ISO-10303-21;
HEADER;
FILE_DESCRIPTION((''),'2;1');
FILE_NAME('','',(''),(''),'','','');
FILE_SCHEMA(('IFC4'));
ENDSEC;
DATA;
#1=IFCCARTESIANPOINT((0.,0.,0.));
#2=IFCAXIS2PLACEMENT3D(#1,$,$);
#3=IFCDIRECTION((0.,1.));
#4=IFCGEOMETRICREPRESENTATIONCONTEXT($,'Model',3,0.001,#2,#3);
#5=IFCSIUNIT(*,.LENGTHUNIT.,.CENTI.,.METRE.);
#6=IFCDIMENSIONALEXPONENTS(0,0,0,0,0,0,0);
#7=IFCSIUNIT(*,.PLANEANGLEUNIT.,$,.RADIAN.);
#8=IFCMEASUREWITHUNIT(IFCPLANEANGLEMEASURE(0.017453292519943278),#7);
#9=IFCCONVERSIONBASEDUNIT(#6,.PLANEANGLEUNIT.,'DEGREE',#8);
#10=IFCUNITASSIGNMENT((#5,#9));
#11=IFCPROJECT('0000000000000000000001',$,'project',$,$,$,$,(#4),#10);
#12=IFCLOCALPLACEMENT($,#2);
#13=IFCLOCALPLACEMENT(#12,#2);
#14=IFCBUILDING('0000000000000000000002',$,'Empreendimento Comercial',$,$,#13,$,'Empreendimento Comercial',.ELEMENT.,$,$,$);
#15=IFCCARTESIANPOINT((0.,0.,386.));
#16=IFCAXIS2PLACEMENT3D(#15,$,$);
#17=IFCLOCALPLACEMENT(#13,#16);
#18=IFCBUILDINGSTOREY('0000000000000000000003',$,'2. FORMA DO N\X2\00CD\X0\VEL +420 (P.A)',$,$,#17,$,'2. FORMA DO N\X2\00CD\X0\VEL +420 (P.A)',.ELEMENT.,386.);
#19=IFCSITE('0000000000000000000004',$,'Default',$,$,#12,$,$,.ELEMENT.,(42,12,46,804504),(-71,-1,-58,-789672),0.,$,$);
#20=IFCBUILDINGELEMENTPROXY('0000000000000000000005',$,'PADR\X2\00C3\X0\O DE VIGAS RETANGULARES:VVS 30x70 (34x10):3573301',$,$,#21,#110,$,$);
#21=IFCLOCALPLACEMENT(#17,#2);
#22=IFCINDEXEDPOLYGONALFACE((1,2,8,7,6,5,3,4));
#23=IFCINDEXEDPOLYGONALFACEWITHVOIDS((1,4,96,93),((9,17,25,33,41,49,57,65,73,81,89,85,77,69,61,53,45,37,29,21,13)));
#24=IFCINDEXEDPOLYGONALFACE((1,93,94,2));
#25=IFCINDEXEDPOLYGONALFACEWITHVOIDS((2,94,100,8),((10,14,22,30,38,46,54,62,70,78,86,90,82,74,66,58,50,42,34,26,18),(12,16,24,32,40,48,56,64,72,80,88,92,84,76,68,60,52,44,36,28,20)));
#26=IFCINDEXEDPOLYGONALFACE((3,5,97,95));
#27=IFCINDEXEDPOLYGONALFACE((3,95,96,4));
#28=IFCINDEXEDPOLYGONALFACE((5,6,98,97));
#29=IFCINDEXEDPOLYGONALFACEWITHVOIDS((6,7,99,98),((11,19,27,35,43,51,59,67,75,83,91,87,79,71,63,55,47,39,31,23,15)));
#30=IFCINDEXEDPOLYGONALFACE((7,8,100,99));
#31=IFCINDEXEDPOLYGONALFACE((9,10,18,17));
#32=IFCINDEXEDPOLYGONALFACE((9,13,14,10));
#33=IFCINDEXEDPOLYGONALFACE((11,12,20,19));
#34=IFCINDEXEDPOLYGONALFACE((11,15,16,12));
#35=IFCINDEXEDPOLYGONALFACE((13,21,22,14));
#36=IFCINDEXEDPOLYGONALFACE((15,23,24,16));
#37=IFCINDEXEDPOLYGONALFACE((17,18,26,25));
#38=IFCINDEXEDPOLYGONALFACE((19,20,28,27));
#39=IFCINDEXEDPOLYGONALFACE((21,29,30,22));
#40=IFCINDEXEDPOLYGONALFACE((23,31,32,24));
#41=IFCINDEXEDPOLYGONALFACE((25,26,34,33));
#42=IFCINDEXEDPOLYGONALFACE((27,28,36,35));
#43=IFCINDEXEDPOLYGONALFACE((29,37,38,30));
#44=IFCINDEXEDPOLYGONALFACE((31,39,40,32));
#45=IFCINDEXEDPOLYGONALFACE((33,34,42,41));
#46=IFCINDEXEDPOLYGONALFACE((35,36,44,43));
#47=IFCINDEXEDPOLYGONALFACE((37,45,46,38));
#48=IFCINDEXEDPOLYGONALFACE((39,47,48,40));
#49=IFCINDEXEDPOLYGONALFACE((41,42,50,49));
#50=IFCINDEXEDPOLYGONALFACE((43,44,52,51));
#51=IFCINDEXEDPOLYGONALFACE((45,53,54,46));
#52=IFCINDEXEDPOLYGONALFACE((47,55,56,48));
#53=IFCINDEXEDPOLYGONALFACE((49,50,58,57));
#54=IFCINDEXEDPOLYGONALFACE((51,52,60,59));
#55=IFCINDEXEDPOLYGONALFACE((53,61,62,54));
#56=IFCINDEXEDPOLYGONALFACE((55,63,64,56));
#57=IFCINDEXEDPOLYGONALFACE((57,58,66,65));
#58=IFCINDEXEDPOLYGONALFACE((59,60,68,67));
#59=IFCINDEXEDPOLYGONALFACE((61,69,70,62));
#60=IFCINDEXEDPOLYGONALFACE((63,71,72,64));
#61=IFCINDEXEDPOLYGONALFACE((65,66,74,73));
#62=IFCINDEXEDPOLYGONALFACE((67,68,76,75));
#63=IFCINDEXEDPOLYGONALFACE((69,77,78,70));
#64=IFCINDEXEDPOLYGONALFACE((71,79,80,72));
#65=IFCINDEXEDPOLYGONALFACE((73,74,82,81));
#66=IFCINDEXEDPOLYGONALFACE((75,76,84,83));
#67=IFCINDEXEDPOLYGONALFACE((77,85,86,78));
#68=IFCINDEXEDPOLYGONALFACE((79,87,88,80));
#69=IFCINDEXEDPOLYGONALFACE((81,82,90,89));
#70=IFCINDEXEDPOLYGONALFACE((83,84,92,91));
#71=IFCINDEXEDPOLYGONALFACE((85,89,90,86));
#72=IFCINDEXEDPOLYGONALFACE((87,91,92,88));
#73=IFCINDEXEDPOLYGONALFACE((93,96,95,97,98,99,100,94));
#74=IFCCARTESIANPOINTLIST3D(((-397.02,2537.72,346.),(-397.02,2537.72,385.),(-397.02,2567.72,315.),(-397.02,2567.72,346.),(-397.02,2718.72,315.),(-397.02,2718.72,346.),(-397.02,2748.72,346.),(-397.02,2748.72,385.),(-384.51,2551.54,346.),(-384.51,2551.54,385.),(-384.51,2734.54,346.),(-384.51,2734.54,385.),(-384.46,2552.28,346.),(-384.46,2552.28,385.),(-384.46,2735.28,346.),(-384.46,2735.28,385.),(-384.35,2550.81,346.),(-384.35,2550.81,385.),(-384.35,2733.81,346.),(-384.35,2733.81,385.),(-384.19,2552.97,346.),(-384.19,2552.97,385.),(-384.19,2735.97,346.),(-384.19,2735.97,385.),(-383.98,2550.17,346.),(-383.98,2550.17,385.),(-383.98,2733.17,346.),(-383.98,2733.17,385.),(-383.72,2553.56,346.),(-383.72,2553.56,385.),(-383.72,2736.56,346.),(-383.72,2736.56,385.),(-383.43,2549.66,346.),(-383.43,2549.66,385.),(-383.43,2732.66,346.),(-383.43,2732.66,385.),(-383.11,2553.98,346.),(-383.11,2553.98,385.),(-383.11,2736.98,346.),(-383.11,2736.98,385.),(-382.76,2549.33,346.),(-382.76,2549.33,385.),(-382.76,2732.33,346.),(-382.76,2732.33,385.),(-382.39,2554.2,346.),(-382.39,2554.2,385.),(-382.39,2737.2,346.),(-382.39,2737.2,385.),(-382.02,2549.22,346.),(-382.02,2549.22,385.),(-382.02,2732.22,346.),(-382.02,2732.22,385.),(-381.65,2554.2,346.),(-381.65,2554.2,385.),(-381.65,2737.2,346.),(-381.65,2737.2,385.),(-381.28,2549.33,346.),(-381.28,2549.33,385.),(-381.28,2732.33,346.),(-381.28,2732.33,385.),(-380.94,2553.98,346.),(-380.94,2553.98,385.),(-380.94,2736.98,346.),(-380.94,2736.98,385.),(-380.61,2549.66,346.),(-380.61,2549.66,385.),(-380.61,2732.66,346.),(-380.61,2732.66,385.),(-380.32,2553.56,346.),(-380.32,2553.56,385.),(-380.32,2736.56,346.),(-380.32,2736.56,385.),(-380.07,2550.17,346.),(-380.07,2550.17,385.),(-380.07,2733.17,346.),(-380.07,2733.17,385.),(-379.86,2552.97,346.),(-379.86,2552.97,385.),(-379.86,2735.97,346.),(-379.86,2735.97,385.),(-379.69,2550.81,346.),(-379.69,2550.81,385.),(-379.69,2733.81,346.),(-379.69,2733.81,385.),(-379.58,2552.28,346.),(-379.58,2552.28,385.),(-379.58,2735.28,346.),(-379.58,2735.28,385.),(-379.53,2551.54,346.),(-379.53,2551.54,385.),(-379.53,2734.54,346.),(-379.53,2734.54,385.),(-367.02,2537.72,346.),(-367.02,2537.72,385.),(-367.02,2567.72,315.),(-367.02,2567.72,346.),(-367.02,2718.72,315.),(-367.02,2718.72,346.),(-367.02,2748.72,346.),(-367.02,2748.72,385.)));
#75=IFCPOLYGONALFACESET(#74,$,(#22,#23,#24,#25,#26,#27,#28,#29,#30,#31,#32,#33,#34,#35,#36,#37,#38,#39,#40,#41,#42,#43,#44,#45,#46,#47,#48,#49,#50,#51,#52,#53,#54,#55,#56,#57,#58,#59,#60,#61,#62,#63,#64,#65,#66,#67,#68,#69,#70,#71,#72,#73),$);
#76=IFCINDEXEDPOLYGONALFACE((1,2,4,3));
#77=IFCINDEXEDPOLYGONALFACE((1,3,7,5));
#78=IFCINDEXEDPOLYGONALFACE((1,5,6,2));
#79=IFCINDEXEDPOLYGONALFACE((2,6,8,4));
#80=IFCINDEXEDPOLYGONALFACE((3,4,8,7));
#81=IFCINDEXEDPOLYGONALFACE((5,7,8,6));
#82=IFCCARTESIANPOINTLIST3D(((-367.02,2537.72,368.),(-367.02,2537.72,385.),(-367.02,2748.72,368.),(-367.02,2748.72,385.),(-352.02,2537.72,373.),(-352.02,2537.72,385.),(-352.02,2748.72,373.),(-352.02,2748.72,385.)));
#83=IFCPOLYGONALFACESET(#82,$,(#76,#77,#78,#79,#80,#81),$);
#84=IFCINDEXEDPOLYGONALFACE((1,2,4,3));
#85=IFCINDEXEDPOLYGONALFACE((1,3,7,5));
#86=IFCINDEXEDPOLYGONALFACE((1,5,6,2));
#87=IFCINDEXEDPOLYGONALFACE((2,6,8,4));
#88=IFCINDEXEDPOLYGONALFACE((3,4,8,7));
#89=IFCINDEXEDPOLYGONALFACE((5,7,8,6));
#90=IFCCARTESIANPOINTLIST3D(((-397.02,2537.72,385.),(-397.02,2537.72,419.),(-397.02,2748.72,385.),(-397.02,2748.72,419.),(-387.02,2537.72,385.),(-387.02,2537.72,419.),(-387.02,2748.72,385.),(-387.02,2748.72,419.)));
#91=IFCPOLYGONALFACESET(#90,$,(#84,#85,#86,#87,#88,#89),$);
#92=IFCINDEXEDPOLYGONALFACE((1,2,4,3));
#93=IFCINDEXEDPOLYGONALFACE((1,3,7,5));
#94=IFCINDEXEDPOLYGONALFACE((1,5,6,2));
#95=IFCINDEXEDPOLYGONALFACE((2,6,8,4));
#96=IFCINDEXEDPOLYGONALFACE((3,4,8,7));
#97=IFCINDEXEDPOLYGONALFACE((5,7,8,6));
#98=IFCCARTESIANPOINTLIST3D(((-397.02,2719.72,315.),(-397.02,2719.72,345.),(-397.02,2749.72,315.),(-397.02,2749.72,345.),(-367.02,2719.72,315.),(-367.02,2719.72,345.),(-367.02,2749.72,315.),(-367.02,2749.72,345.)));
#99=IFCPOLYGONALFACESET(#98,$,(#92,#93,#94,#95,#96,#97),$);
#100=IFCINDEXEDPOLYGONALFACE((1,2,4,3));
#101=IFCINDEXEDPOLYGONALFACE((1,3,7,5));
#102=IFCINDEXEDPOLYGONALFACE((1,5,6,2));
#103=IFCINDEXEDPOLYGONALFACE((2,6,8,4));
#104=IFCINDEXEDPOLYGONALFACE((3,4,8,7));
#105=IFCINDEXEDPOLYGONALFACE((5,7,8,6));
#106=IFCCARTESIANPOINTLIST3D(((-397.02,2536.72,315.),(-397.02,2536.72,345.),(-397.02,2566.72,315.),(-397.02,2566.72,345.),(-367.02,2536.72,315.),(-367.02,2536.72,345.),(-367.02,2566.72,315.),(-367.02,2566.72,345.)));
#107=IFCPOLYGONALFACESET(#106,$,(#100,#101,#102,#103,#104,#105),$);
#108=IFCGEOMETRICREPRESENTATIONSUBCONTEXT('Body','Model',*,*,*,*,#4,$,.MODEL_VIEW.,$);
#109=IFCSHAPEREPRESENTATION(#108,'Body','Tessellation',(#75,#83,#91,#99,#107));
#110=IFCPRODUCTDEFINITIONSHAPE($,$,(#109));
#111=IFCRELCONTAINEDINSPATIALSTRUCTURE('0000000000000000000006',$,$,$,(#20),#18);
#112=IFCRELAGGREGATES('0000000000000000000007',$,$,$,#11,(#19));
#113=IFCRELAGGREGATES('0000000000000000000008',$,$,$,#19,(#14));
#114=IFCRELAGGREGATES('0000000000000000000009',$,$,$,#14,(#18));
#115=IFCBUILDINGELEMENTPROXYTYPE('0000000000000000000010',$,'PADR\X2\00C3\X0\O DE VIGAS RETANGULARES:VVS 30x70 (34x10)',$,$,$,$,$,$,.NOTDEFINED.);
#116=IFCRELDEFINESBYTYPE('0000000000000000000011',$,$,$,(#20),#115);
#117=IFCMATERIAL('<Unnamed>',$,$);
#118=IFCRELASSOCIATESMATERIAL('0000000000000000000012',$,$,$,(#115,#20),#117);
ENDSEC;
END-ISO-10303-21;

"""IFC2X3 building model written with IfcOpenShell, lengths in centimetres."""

from ifc_helpers import new_model, entity, si_unit, converted_unit, direction, frame, frame_2d, origin, origin_2d_with_axis, place, context, subcontext, project, spatial, polyline, rectangle, circle, outline, extrude, source, transform, mapped, material, type_object, type_shapes, element, save


model = new_model("IFC2X3")

# Units and contexts
model_context = context("Model", 3, precision=0.001, world=origin(), true_north=direction((0.0, 1.0)))
body_context = subcontext(model_context, "Body", "Model", "MODEL_VIEW")
ifc_project = project(units=[si_unit("LENGTHUNIT", "METRE", prefix="CENTI"), converted_unit("PLANEANGLEUNIT", "DEGREE", entity("IfcPlaneAngleMeasure", 0.017453292519943278), si_unit("PLANEANGLEUNIT", "RADIAN"), dimensions=[0, 0, 0, 0, 0, 0, 0])], contexts=[model_context])

# Site, building, storey
site_placement = place(None, origin())
site = spatial("IfcSite", under=ifc_project, at=site_placement, Name="Default", CompositionType="ELEMENT", RefLatitude=(42, 12, 46, 804504), RefLongitude=(-71, -1, -58, -789672), RefElevation=0.0)
building_placement = place(site_placement, origin())
building = spatial("IfcBuilding", under=site, at=building_placement, Name="Empreendimento Comercial", LongName="Empreendimento Comercial", CompositionType="ELEMENT")
storey_placement = place(building_placement, frame((0.0, 0.0, 386.0)))
storey = spatial("IfcBuildingStorey", under=building, at=storey_placement, Name="2. FORMA DO NÍVEL +420 (P.A)", LongName="2. FORMA DO NÍVEL +420 (P.A)", CompositionType="ELEMENT", Elevation=386.0)

# Shared definitions
ifc_material_1 = material(Name="<Unnamed>")

# Building element proxy, openings
building_element_proxy_type_1 = type_object("IfcBuildingElementProxyType", Name="PADRÃO DE VIGAS RETANGULARES:VVS 30x70 (34x10)", PredefinedType="NOTDEFINED", material=ifc_material_1)
shared_shape_1 = source(origin(), body_context, "Body", "SweptSolid", [
    extrude(outline(polyline([(-105.5, -37.0), (105.5, -37.0), (105.5, 2.0), (75.5, 2.0), (75.5, 33.0), (-75.5, 33.0), (-75.5, 2.0), (-105.5, 2.0), (-105.5, -37.0)])), frame((-397.02, 2643.22, 734.0), z_axis=(1.0, 0.0, 0.0), x_axis=(0.0, -1.0, 0.0)), (0.0, 0.0, 1.0), 30.0),
    extrude(outline(polyline([(-7.25, -7.5), (4.75, -7.5), (9.75, 7.5), (-7.25, 7.5), (-7.25, -7.5)])), frame((-359.52, 2537.72, 763.75), z_axis=(0.0, 1.0, 0.0), x_axis=(0.0, 0.0, -1.0)), (0.0, 0.0, 1.0), 211.0),
    extrude(rectangle(XDim=211.0, YDim=10.0, at=frame_2d((0.0, 0.0), x_axis=(1.0, 0.0))), frame((-392.02, 2643.22, 771.0), z_axis=(0.0, 0.0, 1.0), x_axis=(0.0, 1.0, 0.0)), (0.0, 0.0, 1.0), 34.0),
    extrude(rectangle(XDim=30.0, YDim=30.0, at=origin_2d_with_axis()), frame((-382.02, 2734.72, 701.0), z_axis=(0.0, 0.0, 1.0), x_axis=(0.0, 1.0, 0.0)), (0.0, 0.0, 1.0), 30.0),
    extrude(rectangle(XDim=30.0, YDim=30.0, at=origin_2d_with_axis()), frame((-382.02, 2551.72, 701.0), z_axis=(0.0, 0.0, 1.0), x_axis=(0.0, 1.0, 0.0)), (0.0, 0.0, 1.0), 30.0),
])
type_shapes(building_element_proxy_type_1, [shared_shape_1])
proxy_1_placement = place(storey_placement, frame((0.0, 0.0, -386.0)))
proxy_1 = element("IfcBuildingElementProxy", 1, at=proxy_1_placement, inside=storey, type_object=building_element_proxy_type_1, material=ifc_material_1, Name="PADRÃO DE VIGAS RETANGULARES:VVS 30x70 (34x10):3573301", context=body_context, shape_type="MappedRepresentation", body=[
    mapped(shared_shape_1, transform((0.0, 0.0, 0.0), scale=1.0)),
])
opening_1_placement = place(storey_placement, frame((0.0, 0.0, -386.0)))
element("IfcOpeningElement", 2, at=opening_1_placement, cuts=proxy_1, ObjectType="Opening", context=body_context, shape_type="SweptSolid", body=[
    extrude(circle(Radius=2.5, at=origin_2d_with_axis()), frame((-382.02, 2551.72, 732.0), z_axis=(0.0, 0.0, 1.0), x_axis=(0.0, -1.0, 0.0)), (0.0, 0.0, 1.0), 39.0),
])
opening_2_placement = place(storey_placement, frame((0.0, 0.0, -386.0)))
element("IfcOpeningElement", 3, at=opening_2_placement, cuts=proxy_1, ObjectType="Opening", context=body_context, shape_type="SweptSolid", body=[
    extrude(circle(Radius=2.5, at=origin_2d_with_axis()), frame((-382.02, 2734.72, 732.0), z_axis=(0.0, 0.0, 1.0), x_axis=(0.0, -1.0, 0.0)), (0.0, 0.0, 1.0), 39.0),
])

save(model, "model.ifc")
